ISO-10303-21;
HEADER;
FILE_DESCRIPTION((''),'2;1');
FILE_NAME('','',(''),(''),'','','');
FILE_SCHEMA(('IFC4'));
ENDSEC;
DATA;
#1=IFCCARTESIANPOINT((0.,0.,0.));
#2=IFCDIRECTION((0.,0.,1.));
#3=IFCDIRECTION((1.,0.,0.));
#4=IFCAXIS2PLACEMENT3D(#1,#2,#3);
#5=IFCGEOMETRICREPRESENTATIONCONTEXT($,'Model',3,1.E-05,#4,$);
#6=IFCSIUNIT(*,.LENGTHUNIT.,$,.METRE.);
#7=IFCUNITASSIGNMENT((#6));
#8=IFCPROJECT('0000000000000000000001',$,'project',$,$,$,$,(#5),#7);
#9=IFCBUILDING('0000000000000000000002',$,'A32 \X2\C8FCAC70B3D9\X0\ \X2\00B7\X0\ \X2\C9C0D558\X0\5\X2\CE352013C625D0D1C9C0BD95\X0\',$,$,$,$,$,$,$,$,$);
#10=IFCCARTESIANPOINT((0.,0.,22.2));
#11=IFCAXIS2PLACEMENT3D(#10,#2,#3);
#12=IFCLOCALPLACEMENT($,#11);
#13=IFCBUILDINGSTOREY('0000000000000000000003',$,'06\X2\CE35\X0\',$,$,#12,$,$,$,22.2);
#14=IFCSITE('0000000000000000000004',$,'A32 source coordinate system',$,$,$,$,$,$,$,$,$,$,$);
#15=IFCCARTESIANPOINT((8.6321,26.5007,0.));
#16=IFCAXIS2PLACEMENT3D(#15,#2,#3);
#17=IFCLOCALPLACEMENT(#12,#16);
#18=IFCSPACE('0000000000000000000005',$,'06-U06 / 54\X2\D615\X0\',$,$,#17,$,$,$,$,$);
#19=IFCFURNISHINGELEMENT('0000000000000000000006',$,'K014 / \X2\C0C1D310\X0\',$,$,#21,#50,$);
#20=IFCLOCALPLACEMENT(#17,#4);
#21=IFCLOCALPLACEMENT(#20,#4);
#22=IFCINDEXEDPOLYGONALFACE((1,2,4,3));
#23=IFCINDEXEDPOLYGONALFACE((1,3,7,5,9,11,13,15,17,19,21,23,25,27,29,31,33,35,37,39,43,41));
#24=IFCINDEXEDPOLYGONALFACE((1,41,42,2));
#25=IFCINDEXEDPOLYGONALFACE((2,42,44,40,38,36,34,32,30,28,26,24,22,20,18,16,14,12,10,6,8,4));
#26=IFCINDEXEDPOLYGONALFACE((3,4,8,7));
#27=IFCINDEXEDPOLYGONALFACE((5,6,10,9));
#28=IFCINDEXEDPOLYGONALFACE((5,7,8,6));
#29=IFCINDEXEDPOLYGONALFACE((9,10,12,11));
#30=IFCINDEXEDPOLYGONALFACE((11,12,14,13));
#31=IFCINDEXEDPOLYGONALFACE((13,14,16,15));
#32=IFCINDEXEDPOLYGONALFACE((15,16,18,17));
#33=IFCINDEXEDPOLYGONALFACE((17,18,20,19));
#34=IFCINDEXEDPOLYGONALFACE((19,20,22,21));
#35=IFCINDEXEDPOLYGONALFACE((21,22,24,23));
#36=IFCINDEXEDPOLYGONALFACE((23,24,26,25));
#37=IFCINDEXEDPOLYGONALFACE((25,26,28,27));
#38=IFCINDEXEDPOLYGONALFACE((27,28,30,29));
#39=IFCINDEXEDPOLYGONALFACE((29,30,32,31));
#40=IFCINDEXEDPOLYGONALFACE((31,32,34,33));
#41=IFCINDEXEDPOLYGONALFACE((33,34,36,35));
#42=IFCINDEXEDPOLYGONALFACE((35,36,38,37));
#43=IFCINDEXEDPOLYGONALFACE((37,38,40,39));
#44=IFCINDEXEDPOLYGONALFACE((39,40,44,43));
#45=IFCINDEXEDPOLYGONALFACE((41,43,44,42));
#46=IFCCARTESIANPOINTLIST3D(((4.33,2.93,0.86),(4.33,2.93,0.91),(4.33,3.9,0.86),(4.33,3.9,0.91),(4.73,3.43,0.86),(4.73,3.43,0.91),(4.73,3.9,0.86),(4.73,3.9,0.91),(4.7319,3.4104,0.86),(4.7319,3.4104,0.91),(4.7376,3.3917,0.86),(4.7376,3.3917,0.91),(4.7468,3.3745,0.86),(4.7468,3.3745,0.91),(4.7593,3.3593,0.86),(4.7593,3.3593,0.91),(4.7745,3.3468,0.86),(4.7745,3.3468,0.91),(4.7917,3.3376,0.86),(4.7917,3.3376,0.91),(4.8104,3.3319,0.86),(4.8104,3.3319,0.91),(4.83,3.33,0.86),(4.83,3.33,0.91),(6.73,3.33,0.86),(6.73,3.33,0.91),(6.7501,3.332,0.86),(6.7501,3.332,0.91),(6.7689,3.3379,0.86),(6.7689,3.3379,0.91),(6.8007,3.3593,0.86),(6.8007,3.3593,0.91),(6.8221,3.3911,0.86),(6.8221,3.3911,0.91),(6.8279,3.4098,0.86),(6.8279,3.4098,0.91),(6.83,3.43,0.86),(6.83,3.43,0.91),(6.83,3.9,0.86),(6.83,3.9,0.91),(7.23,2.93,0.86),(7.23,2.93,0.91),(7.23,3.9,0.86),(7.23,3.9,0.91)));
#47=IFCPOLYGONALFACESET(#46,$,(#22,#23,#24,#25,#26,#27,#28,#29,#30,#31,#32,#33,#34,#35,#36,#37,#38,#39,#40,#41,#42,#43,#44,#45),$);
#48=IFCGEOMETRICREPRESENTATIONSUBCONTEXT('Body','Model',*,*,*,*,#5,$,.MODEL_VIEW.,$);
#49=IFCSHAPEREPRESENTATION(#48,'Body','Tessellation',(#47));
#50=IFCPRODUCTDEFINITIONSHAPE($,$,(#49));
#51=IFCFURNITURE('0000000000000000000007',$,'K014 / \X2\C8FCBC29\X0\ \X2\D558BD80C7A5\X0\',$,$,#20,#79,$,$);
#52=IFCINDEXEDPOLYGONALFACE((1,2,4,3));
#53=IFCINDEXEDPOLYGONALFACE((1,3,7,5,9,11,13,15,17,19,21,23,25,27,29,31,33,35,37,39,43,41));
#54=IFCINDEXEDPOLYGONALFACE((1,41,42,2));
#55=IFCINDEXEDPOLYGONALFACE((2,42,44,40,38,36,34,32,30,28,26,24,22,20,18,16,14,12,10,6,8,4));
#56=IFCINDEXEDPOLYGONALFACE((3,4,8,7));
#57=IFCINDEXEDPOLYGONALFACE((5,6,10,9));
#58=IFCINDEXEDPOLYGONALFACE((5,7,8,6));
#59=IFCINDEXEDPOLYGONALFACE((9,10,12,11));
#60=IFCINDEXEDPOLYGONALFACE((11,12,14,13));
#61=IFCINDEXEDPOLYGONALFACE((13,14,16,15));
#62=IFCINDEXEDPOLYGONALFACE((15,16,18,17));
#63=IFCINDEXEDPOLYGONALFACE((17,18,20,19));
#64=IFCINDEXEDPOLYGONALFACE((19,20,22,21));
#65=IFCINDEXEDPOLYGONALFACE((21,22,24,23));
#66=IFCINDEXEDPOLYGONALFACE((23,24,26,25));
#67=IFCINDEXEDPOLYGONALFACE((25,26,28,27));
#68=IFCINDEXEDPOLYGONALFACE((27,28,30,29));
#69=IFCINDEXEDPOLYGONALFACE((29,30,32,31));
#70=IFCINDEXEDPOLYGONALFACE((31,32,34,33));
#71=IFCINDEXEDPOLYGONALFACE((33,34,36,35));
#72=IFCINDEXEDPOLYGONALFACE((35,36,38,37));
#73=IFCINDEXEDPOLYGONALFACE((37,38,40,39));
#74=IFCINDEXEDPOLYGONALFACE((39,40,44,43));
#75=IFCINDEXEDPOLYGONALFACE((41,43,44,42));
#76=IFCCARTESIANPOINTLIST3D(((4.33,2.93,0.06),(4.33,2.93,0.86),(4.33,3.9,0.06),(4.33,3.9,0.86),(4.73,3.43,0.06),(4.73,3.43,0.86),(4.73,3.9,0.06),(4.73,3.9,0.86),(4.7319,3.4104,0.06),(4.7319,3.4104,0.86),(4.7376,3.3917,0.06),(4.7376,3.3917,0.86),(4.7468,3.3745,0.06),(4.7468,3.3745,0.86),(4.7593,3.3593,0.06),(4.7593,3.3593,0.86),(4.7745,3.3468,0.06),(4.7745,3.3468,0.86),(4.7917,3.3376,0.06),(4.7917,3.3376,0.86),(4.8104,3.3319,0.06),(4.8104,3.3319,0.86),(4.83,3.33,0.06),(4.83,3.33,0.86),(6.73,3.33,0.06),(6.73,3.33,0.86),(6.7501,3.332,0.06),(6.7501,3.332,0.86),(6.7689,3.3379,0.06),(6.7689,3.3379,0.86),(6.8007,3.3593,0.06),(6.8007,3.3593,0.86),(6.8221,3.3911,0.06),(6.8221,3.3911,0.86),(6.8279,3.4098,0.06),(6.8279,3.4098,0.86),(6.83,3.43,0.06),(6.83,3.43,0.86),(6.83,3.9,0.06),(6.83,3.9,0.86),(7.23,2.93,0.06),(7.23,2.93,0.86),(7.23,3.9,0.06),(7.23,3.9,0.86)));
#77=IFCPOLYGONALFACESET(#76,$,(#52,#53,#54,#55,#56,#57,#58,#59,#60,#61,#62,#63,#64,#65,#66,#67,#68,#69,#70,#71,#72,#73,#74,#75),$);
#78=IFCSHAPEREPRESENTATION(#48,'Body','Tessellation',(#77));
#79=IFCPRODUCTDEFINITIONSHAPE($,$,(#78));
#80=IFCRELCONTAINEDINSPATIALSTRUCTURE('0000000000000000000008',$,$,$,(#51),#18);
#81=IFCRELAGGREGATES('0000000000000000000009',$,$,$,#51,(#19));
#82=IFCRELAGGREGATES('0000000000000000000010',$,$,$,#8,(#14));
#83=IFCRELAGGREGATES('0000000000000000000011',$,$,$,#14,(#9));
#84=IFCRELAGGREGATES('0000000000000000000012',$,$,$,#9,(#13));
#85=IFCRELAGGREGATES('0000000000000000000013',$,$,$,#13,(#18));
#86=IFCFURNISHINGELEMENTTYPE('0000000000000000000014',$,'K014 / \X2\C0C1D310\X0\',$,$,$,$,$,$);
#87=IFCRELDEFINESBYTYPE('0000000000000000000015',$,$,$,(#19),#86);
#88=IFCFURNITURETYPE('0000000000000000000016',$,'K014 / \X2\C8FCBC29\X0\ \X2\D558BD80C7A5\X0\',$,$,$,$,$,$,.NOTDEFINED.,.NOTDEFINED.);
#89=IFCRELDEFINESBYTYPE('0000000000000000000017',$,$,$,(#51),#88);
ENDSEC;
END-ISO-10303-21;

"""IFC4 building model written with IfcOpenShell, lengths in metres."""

from ifc_helpers import new_model, si_unit, frame, origin, origin_with_axes, place, context, subcontext, project, spatial, polyline, outline, extrude, source, transform, mapped, type_object, type_shapes, element, aggregate, save


model = new_model("IFC4")

# Units and contexts
model_context = context("Model", 3, precision=1e-05, world=origin_with_axes())
body_context = subcontext(model_context, "Body", "Model", "MODEL_VIEW")
ifc_project = project(units=[si_unit("LENGTHUNIT", "METRE")], contexts=[model_context])

# Site, building, storey, space
site = spatial("IfcSite", under=ifc_project, Name="A32 source coordinate system")
building = spatial("IfcBuilding", under=site, Name="A32 주거동 · 지하5층–옥탑지붕")
storey_placement = place(None, frame((0.0, 0.0, 22.2), z_axis=(0.0, 0.0, 1.0), x_axis=(1.0, 0.0, 0.0)))
storey = spatial("IfcBuildingStorey", under=building, at=storey_placement, Name="06층", Elevation=22.2)
space_placement = place(storey_placement, frame((8.6321, 26.5007, 0.0), z_axis=(0.0, 0.0, 1.0), x_axis=(1.0, 0.0, 0.0)))
space = spatial("IfcSpace", under=storey, at=space_placement, Name="06-U06 / 54형")

# Furnishing element
furnishing_element_type_1 = type_object("IfcFurnishingElementType", Name="K014 / 상판")
shared_shape_1 = source(origin(), body_context, "Body", "SweptSolid", [
    extrude(outline(polyline([(4.33, 2.93), (4.33, 3.9), (4.73, 3.9), (4.73, 3.43), (4.7319, 3.4104), (4.7376, 3.3917), (4.7468, 3.3745), (4.7593, 3.3593), (4.7745, 3.3468), (4.7917, 3.3376), (4.8104, 3.3319), (4.83, 3.33), (6.73, 3.33), (6.7501, 3.332), (6.7689, 3.3379), (6.8007, 3.3593), (6.8221, 3.3911), (6.8279, 3.4098), (6.83, 3.43), (6.83, 3.9), (7.23, 3.9), (7.23, 2.93), (4.33, 2.93)])), frame((0.0, 0.0, 0.86)), (0.0, 0.0, 1.0), 0.05),
])
type_shapes(furnishing_element_type_1, [shared_shape_1])
furniture_1_placement = place(space_placement, origin_with_axes())
furnishing_1_placement = place(furniture_1_placement, origin_with_axes())
furnishing_1 = element("IfcFurnishingElement", 1, at=furnishing_1_placement, type_object=furnishing_element_type_1, Name="K014 / 상판", context=body_context, shape_type="MappedRepresentation", body=[
    mapped(shared_shape_1, transform((0.0, 0.0, 0.0), scale=1.0)),
])

# Furniture
furniture_type_1 = type_object("IfcFurnitureType", Name="K014 / 주방 하부장", AssemblyPlace="NOTDEFINED", PredefinedType="NOTDEFINED")
shared_shape_2 = source(origin(), body_context, "Body", "SweptSolid", [
    extrude(outline(polyline([(7.23, 2.93), (4.33, 2.93), (4.33, 3.9), (4.73, 3.9), (4.73, 3.43), (4.7319, 3.4104), (4.7376, 3.3917), (4.7468, 3.3745), (4.7593, 3.3593), (4.7745, 3.3468), (4.7917, 3.3376), (4.8104, 3.3319), (4.83, 3.33), (6.73, 3.33), (6.7501, 3.332), (6.7689, 3.3379), (6.8007, 3.3593), (6.8221, 3.3911), (6.8279, 3.4098), (6.83, 3.43), (6.83, 3.9), (7.23, 3.9), (7.23, 2.93)])), frame((0.0, 0.0, 0.06)), (0.0, 0.0, 1.0), 0.8),
])
type_shapes(furniture_type_1, [shared_shape_2])
furniture_1 = element("IfcFurniture", 2, at=furniture_1_placement, inside=space, type_object=furniture_type_1, Name="K014 / 주방 하부장", context=body_context, shape_type="MappedRepresentation", body=[
    mapped(shared_shape_2, transform((0.0, 0.0, 0.0), scale=1.0)),
])
aggregate(furniture_1, [furnishing_1])

save(model, "model.ifc")
